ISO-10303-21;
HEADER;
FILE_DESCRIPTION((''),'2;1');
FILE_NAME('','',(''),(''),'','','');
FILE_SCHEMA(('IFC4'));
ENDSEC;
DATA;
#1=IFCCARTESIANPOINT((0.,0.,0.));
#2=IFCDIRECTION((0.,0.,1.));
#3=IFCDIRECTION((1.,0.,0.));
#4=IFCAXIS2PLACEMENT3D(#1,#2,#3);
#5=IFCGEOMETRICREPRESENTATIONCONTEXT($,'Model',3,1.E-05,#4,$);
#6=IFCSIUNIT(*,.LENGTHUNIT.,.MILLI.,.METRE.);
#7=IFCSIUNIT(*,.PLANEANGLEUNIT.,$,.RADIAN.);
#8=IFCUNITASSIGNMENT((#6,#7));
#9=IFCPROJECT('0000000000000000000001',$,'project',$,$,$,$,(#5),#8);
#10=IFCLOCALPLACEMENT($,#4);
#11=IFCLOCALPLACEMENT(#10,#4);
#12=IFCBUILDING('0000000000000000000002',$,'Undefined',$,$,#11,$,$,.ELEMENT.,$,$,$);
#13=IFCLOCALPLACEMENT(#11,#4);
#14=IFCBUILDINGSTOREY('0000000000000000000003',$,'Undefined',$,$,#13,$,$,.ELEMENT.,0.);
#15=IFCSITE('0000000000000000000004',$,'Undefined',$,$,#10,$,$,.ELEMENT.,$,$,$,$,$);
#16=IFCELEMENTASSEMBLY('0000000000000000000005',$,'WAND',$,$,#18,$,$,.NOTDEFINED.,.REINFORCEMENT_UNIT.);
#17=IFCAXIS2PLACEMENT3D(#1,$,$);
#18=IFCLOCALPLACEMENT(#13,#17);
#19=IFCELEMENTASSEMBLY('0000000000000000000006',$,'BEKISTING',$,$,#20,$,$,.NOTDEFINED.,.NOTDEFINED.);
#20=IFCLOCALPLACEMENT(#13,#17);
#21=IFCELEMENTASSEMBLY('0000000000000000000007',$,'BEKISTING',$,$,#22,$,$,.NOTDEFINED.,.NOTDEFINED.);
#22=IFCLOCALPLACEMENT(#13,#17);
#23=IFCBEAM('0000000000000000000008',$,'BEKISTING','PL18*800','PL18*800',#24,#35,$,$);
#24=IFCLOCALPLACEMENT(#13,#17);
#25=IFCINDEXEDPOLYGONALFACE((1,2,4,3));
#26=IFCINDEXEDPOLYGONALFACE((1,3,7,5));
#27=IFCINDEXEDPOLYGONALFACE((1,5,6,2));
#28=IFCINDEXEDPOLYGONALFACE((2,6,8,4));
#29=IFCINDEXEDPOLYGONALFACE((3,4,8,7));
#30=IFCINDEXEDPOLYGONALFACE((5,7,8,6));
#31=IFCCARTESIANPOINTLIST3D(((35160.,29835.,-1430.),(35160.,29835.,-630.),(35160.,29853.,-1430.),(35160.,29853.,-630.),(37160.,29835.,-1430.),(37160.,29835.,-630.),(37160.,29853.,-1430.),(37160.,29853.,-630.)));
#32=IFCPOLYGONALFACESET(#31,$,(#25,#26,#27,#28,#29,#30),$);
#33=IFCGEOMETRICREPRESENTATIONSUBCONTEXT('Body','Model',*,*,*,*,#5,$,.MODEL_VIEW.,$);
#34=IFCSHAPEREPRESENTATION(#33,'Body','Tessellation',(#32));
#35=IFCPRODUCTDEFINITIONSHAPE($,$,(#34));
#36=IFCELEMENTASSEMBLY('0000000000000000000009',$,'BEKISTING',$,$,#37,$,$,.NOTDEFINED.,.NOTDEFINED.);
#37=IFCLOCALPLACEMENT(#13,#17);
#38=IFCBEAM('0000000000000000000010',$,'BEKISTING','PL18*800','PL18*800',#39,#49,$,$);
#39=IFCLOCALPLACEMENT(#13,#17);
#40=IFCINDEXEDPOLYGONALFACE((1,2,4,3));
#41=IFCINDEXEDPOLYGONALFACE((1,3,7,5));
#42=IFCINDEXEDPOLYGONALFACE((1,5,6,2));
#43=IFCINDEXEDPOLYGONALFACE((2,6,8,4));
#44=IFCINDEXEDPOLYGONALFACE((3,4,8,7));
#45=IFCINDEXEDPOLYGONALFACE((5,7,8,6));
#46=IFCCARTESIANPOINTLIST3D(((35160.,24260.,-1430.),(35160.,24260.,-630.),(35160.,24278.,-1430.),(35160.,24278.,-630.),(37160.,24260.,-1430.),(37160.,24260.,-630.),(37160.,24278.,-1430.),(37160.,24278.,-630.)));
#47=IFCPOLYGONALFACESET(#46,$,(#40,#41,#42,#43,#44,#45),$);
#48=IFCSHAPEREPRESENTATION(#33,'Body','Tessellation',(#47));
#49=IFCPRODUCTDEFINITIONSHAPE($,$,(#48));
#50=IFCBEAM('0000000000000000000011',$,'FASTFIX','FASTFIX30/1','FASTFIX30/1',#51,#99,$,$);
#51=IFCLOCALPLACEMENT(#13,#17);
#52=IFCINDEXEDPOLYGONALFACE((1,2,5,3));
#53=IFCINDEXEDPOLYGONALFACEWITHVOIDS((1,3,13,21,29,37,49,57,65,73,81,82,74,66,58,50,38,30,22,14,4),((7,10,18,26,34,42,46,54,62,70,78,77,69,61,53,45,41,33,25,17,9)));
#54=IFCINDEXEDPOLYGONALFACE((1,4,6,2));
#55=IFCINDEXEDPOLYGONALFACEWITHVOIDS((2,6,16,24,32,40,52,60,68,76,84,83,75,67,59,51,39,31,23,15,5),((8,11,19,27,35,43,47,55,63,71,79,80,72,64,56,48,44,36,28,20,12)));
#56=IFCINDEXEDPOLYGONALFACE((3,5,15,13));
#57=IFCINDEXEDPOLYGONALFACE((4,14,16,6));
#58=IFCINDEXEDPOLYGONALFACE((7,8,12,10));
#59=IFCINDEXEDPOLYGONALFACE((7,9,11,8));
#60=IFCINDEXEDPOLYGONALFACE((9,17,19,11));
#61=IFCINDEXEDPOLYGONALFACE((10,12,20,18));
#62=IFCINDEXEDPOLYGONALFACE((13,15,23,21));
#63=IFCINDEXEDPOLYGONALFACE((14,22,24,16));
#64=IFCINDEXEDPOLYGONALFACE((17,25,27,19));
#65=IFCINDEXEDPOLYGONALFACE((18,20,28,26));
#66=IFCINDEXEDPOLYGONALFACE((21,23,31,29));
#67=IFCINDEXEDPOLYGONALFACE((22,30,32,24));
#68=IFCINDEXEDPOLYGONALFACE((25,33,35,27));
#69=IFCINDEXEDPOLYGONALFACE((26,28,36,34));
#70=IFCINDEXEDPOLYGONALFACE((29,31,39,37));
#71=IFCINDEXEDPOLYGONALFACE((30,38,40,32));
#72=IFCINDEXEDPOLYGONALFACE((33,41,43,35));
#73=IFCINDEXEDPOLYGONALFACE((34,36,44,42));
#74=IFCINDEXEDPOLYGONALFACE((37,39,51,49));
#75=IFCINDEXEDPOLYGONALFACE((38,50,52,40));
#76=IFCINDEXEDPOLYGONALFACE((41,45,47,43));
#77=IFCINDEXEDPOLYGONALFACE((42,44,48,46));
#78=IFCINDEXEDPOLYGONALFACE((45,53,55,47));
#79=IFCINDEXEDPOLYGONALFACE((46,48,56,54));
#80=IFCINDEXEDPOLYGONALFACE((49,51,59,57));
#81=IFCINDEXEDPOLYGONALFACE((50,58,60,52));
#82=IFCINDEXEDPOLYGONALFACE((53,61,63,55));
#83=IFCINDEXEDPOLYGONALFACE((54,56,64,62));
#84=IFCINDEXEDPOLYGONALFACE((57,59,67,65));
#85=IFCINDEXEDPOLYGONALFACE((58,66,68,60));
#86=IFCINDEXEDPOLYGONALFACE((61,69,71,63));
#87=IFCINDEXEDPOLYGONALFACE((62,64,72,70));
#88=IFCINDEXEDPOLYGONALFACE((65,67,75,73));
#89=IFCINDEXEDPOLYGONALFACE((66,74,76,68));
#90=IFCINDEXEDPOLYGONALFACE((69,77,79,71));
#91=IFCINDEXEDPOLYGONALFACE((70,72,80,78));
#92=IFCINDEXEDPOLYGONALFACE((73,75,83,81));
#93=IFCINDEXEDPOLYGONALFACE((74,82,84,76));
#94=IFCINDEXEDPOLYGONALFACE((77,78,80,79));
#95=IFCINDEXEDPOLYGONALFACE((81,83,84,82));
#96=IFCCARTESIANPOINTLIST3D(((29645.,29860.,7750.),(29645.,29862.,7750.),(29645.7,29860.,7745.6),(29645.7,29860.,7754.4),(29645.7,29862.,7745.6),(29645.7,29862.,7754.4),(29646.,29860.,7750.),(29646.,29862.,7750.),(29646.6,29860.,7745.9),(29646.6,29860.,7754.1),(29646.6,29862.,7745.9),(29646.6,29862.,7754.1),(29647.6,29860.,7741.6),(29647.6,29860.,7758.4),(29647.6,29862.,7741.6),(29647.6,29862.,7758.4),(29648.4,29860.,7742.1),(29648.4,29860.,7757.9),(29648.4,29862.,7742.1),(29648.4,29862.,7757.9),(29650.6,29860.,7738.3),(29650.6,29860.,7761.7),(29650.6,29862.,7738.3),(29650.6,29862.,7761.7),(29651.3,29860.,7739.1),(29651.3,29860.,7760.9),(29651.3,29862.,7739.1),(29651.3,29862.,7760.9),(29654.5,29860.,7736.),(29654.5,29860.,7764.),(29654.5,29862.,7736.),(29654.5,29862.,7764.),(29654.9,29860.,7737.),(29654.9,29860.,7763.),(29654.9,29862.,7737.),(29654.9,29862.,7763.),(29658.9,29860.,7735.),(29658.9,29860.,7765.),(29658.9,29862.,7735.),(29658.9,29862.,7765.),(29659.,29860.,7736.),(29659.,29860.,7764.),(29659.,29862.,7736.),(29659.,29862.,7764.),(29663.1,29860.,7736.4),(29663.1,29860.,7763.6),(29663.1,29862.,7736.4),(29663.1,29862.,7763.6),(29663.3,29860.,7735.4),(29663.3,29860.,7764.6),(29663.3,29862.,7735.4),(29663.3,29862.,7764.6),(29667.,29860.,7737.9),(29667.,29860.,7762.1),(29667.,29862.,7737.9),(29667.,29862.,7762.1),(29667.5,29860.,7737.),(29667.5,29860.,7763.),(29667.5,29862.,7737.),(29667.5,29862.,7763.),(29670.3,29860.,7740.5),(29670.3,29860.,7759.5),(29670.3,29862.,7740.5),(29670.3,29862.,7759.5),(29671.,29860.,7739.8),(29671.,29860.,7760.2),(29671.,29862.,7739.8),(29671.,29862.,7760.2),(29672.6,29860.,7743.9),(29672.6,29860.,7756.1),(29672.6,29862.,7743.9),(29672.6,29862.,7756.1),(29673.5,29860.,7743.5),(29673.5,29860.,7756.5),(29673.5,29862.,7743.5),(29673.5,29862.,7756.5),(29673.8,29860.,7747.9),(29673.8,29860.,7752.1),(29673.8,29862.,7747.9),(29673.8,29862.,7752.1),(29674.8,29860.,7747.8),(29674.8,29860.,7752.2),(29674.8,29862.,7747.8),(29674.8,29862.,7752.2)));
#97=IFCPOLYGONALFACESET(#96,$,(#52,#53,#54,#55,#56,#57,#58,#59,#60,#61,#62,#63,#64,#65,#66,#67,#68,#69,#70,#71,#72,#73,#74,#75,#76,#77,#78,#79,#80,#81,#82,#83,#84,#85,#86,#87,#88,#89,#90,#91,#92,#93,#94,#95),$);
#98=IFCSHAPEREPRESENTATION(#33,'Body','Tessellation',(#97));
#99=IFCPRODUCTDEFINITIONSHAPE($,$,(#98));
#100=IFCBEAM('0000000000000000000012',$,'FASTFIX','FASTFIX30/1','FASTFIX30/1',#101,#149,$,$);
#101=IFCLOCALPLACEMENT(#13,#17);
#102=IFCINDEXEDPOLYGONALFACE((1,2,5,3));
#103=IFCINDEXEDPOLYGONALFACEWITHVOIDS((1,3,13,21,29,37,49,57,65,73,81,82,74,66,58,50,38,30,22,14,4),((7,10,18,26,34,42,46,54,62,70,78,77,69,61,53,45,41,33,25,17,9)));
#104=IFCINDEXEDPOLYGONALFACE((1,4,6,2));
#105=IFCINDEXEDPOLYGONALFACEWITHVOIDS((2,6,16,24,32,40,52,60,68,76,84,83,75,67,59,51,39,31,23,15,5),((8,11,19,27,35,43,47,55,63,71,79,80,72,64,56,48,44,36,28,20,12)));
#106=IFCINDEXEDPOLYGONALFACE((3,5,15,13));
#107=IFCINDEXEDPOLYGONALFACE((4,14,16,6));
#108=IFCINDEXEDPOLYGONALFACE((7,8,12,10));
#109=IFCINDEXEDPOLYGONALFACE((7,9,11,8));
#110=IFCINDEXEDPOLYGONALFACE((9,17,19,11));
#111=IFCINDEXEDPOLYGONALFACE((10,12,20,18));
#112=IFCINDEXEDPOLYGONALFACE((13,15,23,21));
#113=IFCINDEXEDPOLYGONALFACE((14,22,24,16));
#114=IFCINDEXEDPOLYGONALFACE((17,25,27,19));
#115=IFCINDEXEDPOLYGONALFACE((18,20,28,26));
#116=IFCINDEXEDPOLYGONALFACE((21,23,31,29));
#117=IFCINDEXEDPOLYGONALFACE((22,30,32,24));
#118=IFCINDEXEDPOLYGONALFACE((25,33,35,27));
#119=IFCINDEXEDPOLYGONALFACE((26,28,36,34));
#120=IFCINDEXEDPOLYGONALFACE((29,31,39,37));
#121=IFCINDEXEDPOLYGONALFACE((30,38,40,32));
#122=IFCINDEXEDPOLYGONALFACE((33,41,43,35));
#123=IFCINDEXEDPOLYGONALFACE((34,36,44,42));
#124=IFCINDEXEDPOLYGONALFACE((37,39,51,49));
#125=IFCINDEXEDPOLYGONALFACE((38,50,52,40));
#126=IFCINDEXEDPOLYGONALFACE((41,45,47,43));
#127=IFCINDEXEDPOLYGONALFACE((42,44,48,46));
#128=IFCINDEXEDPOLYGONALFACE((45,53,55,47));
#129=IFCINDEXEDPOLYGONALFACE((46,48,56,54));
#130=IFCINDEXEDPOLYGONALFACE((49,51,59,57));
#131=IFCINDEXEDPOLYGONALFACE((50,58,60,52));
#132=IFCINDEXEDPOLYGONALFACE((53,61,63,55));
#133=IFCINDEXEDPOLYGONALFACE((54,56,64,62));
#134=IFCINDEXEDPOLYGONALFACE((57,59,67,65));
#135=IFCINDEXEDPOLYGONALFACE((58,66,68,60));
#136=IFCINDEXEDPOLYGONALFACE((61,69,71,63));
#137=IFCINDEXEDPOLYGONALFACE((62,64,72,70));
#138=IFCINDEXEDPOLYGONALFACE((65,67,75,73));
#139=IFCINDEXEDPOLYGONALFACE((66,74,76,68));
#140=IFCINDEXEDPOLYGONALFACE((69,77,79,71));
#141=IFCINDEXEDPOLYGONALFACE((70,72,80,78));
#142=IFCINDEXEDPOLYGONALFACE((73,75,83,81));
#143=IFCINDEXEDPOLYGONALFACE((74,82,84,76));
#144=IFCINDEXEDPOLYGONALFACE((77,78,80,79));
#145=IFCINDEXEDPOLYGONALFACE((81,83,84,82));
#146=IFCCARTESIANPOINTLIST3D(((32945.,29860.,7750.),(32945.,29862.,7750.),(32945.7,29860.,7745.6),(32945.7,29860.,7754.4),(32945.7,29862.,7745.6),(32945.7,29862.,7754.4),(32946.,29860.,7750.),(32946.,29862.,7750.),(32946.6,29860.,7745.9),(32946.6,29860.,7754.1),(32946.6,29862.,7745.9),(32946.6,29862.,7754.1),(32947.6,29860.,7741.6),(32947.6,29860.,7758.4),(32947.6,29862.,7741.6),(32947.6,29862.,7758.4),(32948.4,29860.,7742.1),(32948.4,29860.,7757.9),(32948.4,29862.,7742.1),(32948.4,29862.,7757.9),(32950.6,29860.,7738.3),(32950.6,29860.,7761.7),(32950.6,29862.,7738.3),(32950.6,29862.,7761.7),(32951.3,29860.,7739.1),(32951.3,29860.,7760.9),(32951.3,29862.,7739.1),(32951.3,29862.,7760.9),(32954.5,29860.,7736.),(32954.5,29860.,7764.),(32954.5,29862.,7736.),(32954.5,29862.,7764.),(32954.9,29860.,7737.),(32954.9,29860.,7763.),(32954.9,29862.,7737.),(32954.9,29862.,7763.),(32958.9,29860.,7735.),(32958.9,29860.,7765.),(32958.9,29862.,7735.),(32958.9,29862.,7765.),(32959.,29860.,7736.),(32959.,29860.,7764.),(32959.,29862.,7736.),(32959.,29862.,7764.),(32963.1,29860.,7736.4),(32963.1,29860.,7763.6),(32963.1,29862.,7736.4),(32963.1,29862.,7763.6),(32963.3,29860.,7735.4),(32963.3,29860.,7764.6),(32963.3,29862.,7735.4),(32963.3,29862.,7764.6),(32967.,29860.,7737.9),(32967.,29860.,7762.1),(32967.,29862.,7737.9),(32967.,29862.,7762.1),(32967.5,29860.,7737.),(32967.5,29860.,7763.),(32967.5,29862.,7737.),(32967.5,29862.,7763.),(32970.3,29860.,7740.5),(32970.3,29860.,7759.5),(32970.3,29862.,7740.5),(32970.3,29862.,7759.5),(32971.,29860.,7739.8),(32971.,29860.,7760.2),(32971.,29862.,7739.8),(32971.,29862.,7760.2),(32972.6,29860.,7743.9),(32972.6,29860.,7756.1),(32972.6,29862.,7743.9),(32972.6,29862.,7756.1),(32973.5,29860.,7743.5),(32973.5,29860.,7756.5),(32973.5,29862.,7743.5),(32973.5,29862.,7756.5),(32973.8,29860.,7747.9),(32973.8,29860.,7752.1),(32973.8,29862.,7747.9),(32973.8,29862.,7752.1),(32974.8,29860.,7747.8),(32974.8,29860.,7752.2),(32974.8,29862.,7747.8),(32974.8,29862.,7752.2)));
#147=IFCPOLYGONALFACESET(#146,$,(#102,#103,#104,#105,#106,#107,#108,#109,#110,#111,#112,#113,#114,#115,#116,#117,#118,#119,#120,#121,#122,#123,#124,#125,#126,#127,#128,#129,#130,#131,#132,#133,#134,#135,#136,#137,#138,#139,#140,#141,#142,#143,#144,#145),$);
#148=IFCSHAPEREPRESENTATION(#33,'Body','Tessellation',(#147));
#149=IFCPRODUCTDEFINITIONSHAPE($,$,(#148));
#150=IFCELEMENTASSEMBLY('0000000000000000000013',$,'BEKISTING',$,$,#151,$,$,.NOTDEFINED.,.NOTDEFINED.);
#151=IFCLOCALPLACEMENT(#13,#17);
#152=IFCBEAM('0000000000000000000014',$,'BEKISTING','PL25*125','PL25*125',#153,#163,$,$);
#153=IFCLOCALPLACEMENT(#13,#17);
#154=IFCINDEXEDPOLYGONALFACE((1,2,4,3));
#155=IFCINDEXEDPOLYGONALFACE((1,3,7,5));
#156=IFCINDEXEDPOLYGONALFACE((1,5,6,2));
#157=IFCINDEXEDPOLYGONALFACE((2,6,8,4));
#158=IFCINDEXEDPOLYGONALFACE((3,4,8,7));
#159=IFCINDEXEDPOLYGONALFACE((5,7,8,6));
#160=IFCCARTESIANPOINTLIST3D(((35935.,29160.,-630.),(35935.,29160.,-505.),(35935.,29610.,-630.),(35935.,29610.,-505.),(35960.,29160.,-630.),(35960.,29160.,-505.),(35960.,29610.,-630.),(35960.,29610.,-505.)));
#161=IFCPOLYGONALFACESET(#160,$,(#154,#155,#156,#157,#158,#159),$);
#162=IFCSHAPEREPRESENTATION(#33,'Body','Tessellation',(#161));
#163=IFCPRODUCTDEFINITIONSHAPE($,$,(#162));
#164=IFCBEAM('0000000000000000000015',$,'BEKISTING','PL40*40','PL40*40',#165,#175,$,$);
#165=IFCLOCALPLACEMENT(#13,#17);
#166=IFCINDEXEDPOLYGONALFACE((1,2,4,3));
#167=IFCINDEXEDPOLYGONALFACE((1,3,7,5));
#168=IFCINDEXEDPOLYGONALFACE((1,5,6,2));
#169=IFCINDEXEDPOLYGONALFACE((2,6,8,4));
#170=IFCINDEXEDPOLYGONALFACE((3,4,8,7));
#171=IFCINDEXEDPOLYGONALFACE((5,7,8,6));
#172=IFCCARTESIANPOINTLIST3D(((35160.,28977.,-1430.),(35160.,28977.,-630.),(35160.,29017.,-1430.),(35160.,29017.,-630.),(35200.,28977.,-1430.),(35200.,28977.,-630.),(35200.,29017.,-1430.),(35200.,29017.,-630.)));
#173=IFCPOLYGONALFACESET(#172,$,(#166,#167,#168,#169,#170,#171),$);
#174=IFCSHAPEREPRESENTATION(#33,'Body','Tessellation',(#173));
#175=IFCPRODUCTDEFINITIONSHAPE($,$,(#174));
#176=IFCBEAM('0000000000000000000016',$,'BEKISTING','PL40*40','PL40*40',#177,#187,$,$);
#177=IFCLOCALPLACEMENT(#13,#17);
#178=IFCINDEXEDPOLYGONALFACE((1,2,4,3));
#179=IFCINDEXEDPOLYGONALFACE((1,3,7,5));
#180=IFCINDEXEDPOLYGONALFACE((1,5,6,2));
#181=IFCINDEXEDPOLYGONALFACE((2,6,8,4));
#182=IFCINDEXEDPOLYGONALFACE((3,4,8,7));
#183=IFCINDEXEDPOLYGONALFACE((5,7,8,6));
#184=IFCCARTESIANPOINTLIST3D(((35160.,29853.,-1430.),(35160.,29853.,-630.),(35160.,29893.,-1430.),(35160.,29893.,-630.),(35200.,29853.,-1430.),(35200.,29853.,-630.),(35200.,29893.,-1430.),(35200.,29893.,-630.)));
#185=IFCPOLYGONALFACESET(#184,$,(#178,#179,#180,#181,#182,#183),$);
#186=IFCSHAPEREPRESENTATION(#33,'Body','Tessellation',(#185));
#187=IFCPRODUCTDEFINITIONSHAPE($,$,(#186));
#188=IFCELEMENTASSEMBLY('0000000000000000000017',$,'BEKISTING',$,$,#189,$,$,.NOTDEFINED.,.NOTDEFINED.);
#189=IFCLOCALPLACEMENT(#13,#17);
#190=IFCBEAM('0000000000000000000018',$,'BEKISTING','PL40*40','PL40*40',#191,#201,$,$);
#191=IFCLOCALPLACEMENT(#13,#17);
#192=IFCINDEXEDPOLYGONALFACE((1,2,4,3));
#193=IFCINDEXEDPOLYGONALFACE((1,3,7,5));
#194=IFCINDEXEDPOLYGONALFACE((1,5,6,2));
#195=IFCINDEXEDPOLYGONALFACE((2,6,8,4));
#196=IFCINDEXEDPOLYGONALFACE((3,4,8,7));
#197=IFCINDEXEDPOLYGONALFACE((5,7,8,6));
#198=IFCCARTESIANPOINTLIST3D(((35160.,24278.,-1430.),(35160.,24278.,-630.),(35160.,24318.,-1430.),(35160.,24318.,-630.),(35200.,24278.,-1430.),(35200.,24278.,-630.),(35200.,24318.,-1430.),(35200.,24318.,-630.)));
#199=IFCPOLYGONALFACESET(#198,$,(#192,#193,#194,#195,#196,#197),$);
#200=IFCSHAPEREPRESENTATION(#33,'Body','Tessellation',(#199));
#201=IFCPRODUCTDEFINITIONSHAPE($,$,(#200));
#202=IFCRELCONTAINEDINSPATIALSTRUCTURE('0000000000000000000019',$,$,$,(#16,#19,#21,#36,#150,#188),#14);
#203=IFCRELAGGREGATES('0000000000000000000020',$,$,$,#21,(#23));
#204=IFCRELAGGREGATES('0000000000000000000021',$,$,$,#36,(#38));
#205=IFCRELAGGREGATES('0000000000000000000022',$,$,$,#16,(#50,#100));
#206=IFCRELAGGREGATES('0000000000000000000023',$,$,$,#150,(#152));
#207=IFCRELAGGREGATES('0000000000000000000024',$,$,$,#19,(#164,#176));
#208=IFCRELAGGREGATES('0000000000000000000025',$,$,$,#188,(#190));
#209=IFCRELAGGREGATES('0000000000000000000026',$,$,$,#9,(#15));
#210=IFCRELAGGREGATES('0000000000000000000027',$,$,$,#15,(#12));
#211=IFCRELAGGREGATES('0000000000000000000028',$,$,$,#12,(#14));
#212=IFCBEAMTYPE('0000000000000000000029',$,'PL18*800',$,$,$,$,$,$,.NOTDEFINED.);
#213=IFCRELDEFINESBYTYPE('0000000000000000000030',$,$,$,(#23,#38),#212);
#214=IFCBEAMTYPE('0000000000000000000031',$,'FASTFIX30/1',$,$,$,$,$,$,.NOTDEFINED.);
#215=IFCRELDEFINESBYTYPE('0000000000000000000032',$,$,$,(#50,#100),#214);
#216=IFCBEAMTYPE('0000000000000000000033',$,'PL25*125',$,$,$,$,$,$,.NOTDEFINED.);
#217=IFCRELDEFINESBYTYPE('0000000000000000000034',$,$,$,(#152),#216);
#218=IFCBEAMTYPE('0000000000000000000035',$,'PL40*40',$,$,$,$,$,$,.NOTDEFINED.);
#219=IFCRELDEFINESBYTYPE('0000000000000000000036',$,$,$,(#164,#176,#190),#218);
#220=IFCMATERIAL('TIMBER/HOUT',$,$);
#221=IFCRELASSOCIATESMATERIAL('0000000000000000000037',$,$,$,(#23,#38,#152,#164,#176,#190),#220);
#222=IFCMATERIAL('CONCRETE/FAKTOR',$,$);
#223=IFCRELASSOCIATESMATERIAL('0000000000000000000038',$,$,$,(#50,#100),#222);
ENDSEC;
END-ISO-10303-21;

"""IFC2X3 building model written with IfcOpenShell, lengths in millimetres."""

from ifc_helpers import new_model, si_unit, frame, frame_2d, origin_with_axes, place, context, subcontext, project, spatial, rectangle, hollow_circle, extrude, material, type_object, element, aggregate, save


model = new_model("IFC2X3")

# Units and contexts
model_context = context("Model", 3, precision=1e-05, world=origin_with_axes())
body_context = subcontext(model_context, "Body", "Model", "MODEL_VIEW")
ifc_project = project(units=[si_unit("LENGTHUNIT", "METRE", prefix="MILLI"), si_unit("PLANEANGLEUNIT", "RADIAN")], contexts=[model_context])

# Site, building, storey
site_placement = place(None, origin_with_axes())
site = spatial("IfcSite", under=ifc_project, at=site_placement, Name="Undefined", CompositionType="ELEMENT")
building_placement = place(site_placement, origin_with_axes())
building = spatial("IfcBuilding", under=site, at=building_placement, Name="Undefined", CompositionType="ELEMENT")
storey_placement = place(building_placement, origin_with_axes())
storey = spatial("IfcBuildingStorey", under=building, at=storey_placement, Name="Undefined", CompositionType="ELEMENT", Elevation=0.0)

# Element assembly
assembly_1_placement = place(storey_placement, origin_with_axes())
assembly_1 = element("IfcElementAssembly", 1, at=assembly_1_placement, inside=storey, Name="WAND", AssemblyPlace="NOTDEFINED", PredefinedType="REINFORCEMENT_UNIT")

# Shared definitions
ifc_material_1 = material(Name="CONCRETE/FAKTOR")

# Element assemblies, beams
assembly_2_placement = place(storey_placement, origin_with_axes())
assembly_2 = element("IfcElementAssembly", 2, at=assembly_2_placement, inside=storey, Name="BEKISTING", AssemblyPlace="NOTDEFINED", PredefinedType="NOTDEFINED")
ifc_material_2 = material(Name="TIMBER/HOUT")
beam_type_1 = type_object("IfcBeamType", Name="PL18*800", PredefinedType="NOTDEFINED")
assembly_3_placement = place(storey_placement, origin_with_axes())
assembly_3 = element("IfcElementAssembly", 3, at=assembly_3_placement, inside=storey, Name="BEKISTING", AssemblyPlace="NOTDEFINED", PredefinedType="NOTDEFINED")
beam_1_placement = place(assembly_3_placement, frame((35160.0, 29844.0, -1030.0), z_axis=(0.0, 0.0, 1.0), x_axis=(1.0, 0.0, 0.0)))
beam_1 = element("IfcBeam", 4, at=beam_1_placement, type_object=beam_type_1, material=ifc_material_2, Name="BEKISTING", Description="PL18*800", ObjectType="PL18*800", context=body_context, shape_type="SweptSolid", body=[
    extrude(rectangle(XDim=18.0, YDim=800.0, at=frame_2d((0.0, 0.0), x_axis=(1.0, 0.0))), frame((2000.0, 0.0, 0.0), z_axis=(-1.0, 0.0, 0.0), x_axis=(0.0, -1.0, 0.0)), (0.0, 0.0, 1.0), 2000.0),
])
aggregate(assembly_3, [beam_1])
assembly_4_placement = place(storey_placement, origin_with_axes())
assembly_4 = element("IfcElementAssembly", 5, at=assembly_4_placement, inside=storey, Name="BEKISTING", AssemblyPlace="NOTDEFINED", PredefinedType="NOTDEFINED")
beam_2_placement = place(assembly_4_placement, frame((35160.0, 24269.0, -1030.0), z_axis=(0.0, 0.0, 1.0), x_axis=(1.0, 0.0, 0.0)))
beam_2 = element("IfcBeam", 6, at=beam_2_placement, type_object=beam_type_1, material=ifc_material_2, Name="BEKISTING", Description="PL18*800", ObjectType="PL18*800", context=body_context, shape_type="SweptSolid", body=[
    extrude(rectangle(XDim=18.0, YDim=800.0, at=frame_2d((0.0, 0.0), x_axis=(1.0, 0.0))), frame((2000.0, 0.0, 0.0), z_axis=(-1.0, 0.0, 0.0), x_axis=(0.0, -1.0, 0.0)), (0.0, 0.0, 1.0), 2000.0),
])
aggregate(assembly_4, [beam_2])

# Beams
beam_type_2 = type_object("IfcBeamType", Name="FASTFIX30/1", PredefinedType="NOTDEFINED")
beam_3_placement = place(assembly_1_placement, frame((29660.0, 29860.0, 7750.0), z_axis=(0.0, 0.0, -1.0), x_axis=(0.0, 1.0, 0.0)))
beam_3 = element("IfcBeam", 7, at=beam_3_placement, type_object=beam_type_2, material=ifc_material_1, Name="FASTFIX", Description="FASTFIX30/1", ObjectType="FASTFIX30/1", context=body_context, shape_type="SweptSolid", body=[
    extrude(hollow_circle(Radius=15.0, WallThickness=1.0, at=frame_2d((0.0, 0.0), x_axis=(1.0, 0.0))), frame((2.0, 0.0, 0.0), z_axis=(-1.0, 0.0, 0.0), x_axis=(0.0, -1.0, 0.0)), (0.0, 0.0, 1.0), 2.0),
])
beam_4_placement = place(assembly_1_placement, frame((32960.0, 29860.0, 7750.0), z_axis=(0.0, 0.0, -1.0), x_axis=(0.0, 1.0, 0.0)))
beam_4 = element("IfcBeam", 8, at=beam_4_placement, type_object=beam_type_2, material=ifc_material_1, Name="FASTFIX", Description="FASTFIX30/1", ObjectType="FASTFIX30/1", context=body_context, shape_type="SweptSolid", body=[
    extrude(hollow_circle(Radius=15.0, WallThickness=1.0, at=frame_2d((0.0, 0.0), x_axis=(1.0, 0.0))), frame((2.0, 0.0, 0.0), z_axis=(-1.0, 0.0, 0.0), x_axis=(0.0, -1.0, 0.0)), (0.0, 0.0, 1.0), 2.0),
])
aggregate(assembly_1, [beam_3, beam_4])

# Element assembly, beam
assembly_5_placement = place(storey_placement, origin_with_axes())
assembly_5 = element("IfcElementAssembly", 9, at=assembly_5_placement, inside=storey, Name="BEKISTING", AssemblyPlace="NOTDEFINED", PredefinedType="NOTDEFINED")
beam_type_3 = type_object("IfcBeamType", Name="PL25*125", PredefinedType="NOTDEFINED")
beam_5_placement = place(assembly_5_placement, frame((35947.5, 29160.0, -567.5), z_axis=(0.0, 0.0, -1.0), x_axis=(0.0, 1.0, 0.0)))
beam_5 = element("IfcBeam", 10, at=beam_5_placement, type_object=beam_type_3, material=ifc_material_2, Name="BEKISTING", Description="PL25*125", ObjectType="PL25*125", context=body_context, shape_type="SweptSolid", body=[
    extrude(rectangle(XDim=25.0, YDim=125.0, at=frame_2d((0.0, 0.0), x_axis=(1.0, 0.0))), frame((450.0, 0.0, 0.0), z_axis=(-1.0, 0.0, 0.0), x_axis=(0.0, -1.0, 0.0)), (0.0, 0.0, 1.0), 450.0),
])
aggregate(assembly_5, [beam_5])

# Beams
beam_type_4 = type_object("IfcBeamType", Name="PL40*40", PredefinedType="NOTDEFINED")
beam_6_placement = place(assembly_2_placement, frame((35180.0, 28997.0, -1430.0), z_axis=(0.0, 1.0, 0.0), x_axis=(0.0, 0.0, 1.0)))
beam_6 = element("IfcBeam", 11, at=beam_6_placement, type_object=beam_type_4, material=ifc_material_2, Name="BEKISTING", Description="PL40*40", ObjectType="PL40*40", context=body_context, shape_type="SweptSolid", body=[
    extrude(rectangle(XDim=40.0, YDim=40.0, at=frame_2d((0.0, 0.0), x_axis=(1.0, 0.0))), frame((800.0, 0.0, 0.0), z_axis=(-1.0, 0.0, 0.0), x_axis=(0.0, -1.0, 0.0)), (0.0, 0.0, 1.0), 800.0),
])
beam_7_placement = place(assembly_2_placement, frame((35180.0, 29873.0, -1430.0), z_axis=(0.0, 1.0, 0.0), x_axis=(0.0, 0.0, 1.0)))
beam_7 = element("IfcBeam", 12, at=beam_7_placement, type_object=beam_type_4, material=ifc_material_2, Name="BEKISTING", Description="PL40*40", ObjectType="PL40*40", context=body_context, shape_type="SweptSolid", body=[
    extrude(rectangle(XDim=40.0, YDim=40.0, at=frame_2d((0.0, 0.0), x_axis=(1.0, 0.0))), frame((800.0, 0.0, 0.0), z_axis=(-1.0, 0.0, 0.0), x_axis=(0.0, -1.0, 0.0)), (0.0, 0.0, 1.0), 800.0),
])
aggregate(assembly_2, [beam_6, beam_7])

# Element assembly, beam
assembly_6_placement = place(storey_placement, origin_with_axes())
assembly_6 = element("IfcElementAssembly", 13, at=assembly_6_placement, inside=storey, Name="BEKISTING", AssemblyPlace="NOTDEFINED", PredefinedType="NOTDEFINED")
beam_8_placement = place(assembly_6_placement, frame((35180.0, 24298.0, -1430.0), z_axis=(0.0, 1.0, 0.0), x_axis=(0.0, 0.0, 1.0)))
beam_8 = element("IfcBeam", 14, at=beam_8_placement, type_object=beam_type_4, material=ifc_material_2, Name="BEKISTING", Description="PL40*40", ObjectType="PL40*40", context=body_context, shape_type="SweptSolid", body=[
    extrude(rectangle(XDim=40.0, YDim=40.0, at=frame_2d((0.0, 0.0), x_axis=(1.0, 0.0))), frame((800.0, 0.0, 0.0), z_axis=(-1.0, 0.0, 0.0), x_axis=(0.0, -1.0, 0.0)), (0.0, 0.0, 1.0), 800.0),
])
aggregate(assembly_6, [beam_8])

save(model, "model.ifc")
